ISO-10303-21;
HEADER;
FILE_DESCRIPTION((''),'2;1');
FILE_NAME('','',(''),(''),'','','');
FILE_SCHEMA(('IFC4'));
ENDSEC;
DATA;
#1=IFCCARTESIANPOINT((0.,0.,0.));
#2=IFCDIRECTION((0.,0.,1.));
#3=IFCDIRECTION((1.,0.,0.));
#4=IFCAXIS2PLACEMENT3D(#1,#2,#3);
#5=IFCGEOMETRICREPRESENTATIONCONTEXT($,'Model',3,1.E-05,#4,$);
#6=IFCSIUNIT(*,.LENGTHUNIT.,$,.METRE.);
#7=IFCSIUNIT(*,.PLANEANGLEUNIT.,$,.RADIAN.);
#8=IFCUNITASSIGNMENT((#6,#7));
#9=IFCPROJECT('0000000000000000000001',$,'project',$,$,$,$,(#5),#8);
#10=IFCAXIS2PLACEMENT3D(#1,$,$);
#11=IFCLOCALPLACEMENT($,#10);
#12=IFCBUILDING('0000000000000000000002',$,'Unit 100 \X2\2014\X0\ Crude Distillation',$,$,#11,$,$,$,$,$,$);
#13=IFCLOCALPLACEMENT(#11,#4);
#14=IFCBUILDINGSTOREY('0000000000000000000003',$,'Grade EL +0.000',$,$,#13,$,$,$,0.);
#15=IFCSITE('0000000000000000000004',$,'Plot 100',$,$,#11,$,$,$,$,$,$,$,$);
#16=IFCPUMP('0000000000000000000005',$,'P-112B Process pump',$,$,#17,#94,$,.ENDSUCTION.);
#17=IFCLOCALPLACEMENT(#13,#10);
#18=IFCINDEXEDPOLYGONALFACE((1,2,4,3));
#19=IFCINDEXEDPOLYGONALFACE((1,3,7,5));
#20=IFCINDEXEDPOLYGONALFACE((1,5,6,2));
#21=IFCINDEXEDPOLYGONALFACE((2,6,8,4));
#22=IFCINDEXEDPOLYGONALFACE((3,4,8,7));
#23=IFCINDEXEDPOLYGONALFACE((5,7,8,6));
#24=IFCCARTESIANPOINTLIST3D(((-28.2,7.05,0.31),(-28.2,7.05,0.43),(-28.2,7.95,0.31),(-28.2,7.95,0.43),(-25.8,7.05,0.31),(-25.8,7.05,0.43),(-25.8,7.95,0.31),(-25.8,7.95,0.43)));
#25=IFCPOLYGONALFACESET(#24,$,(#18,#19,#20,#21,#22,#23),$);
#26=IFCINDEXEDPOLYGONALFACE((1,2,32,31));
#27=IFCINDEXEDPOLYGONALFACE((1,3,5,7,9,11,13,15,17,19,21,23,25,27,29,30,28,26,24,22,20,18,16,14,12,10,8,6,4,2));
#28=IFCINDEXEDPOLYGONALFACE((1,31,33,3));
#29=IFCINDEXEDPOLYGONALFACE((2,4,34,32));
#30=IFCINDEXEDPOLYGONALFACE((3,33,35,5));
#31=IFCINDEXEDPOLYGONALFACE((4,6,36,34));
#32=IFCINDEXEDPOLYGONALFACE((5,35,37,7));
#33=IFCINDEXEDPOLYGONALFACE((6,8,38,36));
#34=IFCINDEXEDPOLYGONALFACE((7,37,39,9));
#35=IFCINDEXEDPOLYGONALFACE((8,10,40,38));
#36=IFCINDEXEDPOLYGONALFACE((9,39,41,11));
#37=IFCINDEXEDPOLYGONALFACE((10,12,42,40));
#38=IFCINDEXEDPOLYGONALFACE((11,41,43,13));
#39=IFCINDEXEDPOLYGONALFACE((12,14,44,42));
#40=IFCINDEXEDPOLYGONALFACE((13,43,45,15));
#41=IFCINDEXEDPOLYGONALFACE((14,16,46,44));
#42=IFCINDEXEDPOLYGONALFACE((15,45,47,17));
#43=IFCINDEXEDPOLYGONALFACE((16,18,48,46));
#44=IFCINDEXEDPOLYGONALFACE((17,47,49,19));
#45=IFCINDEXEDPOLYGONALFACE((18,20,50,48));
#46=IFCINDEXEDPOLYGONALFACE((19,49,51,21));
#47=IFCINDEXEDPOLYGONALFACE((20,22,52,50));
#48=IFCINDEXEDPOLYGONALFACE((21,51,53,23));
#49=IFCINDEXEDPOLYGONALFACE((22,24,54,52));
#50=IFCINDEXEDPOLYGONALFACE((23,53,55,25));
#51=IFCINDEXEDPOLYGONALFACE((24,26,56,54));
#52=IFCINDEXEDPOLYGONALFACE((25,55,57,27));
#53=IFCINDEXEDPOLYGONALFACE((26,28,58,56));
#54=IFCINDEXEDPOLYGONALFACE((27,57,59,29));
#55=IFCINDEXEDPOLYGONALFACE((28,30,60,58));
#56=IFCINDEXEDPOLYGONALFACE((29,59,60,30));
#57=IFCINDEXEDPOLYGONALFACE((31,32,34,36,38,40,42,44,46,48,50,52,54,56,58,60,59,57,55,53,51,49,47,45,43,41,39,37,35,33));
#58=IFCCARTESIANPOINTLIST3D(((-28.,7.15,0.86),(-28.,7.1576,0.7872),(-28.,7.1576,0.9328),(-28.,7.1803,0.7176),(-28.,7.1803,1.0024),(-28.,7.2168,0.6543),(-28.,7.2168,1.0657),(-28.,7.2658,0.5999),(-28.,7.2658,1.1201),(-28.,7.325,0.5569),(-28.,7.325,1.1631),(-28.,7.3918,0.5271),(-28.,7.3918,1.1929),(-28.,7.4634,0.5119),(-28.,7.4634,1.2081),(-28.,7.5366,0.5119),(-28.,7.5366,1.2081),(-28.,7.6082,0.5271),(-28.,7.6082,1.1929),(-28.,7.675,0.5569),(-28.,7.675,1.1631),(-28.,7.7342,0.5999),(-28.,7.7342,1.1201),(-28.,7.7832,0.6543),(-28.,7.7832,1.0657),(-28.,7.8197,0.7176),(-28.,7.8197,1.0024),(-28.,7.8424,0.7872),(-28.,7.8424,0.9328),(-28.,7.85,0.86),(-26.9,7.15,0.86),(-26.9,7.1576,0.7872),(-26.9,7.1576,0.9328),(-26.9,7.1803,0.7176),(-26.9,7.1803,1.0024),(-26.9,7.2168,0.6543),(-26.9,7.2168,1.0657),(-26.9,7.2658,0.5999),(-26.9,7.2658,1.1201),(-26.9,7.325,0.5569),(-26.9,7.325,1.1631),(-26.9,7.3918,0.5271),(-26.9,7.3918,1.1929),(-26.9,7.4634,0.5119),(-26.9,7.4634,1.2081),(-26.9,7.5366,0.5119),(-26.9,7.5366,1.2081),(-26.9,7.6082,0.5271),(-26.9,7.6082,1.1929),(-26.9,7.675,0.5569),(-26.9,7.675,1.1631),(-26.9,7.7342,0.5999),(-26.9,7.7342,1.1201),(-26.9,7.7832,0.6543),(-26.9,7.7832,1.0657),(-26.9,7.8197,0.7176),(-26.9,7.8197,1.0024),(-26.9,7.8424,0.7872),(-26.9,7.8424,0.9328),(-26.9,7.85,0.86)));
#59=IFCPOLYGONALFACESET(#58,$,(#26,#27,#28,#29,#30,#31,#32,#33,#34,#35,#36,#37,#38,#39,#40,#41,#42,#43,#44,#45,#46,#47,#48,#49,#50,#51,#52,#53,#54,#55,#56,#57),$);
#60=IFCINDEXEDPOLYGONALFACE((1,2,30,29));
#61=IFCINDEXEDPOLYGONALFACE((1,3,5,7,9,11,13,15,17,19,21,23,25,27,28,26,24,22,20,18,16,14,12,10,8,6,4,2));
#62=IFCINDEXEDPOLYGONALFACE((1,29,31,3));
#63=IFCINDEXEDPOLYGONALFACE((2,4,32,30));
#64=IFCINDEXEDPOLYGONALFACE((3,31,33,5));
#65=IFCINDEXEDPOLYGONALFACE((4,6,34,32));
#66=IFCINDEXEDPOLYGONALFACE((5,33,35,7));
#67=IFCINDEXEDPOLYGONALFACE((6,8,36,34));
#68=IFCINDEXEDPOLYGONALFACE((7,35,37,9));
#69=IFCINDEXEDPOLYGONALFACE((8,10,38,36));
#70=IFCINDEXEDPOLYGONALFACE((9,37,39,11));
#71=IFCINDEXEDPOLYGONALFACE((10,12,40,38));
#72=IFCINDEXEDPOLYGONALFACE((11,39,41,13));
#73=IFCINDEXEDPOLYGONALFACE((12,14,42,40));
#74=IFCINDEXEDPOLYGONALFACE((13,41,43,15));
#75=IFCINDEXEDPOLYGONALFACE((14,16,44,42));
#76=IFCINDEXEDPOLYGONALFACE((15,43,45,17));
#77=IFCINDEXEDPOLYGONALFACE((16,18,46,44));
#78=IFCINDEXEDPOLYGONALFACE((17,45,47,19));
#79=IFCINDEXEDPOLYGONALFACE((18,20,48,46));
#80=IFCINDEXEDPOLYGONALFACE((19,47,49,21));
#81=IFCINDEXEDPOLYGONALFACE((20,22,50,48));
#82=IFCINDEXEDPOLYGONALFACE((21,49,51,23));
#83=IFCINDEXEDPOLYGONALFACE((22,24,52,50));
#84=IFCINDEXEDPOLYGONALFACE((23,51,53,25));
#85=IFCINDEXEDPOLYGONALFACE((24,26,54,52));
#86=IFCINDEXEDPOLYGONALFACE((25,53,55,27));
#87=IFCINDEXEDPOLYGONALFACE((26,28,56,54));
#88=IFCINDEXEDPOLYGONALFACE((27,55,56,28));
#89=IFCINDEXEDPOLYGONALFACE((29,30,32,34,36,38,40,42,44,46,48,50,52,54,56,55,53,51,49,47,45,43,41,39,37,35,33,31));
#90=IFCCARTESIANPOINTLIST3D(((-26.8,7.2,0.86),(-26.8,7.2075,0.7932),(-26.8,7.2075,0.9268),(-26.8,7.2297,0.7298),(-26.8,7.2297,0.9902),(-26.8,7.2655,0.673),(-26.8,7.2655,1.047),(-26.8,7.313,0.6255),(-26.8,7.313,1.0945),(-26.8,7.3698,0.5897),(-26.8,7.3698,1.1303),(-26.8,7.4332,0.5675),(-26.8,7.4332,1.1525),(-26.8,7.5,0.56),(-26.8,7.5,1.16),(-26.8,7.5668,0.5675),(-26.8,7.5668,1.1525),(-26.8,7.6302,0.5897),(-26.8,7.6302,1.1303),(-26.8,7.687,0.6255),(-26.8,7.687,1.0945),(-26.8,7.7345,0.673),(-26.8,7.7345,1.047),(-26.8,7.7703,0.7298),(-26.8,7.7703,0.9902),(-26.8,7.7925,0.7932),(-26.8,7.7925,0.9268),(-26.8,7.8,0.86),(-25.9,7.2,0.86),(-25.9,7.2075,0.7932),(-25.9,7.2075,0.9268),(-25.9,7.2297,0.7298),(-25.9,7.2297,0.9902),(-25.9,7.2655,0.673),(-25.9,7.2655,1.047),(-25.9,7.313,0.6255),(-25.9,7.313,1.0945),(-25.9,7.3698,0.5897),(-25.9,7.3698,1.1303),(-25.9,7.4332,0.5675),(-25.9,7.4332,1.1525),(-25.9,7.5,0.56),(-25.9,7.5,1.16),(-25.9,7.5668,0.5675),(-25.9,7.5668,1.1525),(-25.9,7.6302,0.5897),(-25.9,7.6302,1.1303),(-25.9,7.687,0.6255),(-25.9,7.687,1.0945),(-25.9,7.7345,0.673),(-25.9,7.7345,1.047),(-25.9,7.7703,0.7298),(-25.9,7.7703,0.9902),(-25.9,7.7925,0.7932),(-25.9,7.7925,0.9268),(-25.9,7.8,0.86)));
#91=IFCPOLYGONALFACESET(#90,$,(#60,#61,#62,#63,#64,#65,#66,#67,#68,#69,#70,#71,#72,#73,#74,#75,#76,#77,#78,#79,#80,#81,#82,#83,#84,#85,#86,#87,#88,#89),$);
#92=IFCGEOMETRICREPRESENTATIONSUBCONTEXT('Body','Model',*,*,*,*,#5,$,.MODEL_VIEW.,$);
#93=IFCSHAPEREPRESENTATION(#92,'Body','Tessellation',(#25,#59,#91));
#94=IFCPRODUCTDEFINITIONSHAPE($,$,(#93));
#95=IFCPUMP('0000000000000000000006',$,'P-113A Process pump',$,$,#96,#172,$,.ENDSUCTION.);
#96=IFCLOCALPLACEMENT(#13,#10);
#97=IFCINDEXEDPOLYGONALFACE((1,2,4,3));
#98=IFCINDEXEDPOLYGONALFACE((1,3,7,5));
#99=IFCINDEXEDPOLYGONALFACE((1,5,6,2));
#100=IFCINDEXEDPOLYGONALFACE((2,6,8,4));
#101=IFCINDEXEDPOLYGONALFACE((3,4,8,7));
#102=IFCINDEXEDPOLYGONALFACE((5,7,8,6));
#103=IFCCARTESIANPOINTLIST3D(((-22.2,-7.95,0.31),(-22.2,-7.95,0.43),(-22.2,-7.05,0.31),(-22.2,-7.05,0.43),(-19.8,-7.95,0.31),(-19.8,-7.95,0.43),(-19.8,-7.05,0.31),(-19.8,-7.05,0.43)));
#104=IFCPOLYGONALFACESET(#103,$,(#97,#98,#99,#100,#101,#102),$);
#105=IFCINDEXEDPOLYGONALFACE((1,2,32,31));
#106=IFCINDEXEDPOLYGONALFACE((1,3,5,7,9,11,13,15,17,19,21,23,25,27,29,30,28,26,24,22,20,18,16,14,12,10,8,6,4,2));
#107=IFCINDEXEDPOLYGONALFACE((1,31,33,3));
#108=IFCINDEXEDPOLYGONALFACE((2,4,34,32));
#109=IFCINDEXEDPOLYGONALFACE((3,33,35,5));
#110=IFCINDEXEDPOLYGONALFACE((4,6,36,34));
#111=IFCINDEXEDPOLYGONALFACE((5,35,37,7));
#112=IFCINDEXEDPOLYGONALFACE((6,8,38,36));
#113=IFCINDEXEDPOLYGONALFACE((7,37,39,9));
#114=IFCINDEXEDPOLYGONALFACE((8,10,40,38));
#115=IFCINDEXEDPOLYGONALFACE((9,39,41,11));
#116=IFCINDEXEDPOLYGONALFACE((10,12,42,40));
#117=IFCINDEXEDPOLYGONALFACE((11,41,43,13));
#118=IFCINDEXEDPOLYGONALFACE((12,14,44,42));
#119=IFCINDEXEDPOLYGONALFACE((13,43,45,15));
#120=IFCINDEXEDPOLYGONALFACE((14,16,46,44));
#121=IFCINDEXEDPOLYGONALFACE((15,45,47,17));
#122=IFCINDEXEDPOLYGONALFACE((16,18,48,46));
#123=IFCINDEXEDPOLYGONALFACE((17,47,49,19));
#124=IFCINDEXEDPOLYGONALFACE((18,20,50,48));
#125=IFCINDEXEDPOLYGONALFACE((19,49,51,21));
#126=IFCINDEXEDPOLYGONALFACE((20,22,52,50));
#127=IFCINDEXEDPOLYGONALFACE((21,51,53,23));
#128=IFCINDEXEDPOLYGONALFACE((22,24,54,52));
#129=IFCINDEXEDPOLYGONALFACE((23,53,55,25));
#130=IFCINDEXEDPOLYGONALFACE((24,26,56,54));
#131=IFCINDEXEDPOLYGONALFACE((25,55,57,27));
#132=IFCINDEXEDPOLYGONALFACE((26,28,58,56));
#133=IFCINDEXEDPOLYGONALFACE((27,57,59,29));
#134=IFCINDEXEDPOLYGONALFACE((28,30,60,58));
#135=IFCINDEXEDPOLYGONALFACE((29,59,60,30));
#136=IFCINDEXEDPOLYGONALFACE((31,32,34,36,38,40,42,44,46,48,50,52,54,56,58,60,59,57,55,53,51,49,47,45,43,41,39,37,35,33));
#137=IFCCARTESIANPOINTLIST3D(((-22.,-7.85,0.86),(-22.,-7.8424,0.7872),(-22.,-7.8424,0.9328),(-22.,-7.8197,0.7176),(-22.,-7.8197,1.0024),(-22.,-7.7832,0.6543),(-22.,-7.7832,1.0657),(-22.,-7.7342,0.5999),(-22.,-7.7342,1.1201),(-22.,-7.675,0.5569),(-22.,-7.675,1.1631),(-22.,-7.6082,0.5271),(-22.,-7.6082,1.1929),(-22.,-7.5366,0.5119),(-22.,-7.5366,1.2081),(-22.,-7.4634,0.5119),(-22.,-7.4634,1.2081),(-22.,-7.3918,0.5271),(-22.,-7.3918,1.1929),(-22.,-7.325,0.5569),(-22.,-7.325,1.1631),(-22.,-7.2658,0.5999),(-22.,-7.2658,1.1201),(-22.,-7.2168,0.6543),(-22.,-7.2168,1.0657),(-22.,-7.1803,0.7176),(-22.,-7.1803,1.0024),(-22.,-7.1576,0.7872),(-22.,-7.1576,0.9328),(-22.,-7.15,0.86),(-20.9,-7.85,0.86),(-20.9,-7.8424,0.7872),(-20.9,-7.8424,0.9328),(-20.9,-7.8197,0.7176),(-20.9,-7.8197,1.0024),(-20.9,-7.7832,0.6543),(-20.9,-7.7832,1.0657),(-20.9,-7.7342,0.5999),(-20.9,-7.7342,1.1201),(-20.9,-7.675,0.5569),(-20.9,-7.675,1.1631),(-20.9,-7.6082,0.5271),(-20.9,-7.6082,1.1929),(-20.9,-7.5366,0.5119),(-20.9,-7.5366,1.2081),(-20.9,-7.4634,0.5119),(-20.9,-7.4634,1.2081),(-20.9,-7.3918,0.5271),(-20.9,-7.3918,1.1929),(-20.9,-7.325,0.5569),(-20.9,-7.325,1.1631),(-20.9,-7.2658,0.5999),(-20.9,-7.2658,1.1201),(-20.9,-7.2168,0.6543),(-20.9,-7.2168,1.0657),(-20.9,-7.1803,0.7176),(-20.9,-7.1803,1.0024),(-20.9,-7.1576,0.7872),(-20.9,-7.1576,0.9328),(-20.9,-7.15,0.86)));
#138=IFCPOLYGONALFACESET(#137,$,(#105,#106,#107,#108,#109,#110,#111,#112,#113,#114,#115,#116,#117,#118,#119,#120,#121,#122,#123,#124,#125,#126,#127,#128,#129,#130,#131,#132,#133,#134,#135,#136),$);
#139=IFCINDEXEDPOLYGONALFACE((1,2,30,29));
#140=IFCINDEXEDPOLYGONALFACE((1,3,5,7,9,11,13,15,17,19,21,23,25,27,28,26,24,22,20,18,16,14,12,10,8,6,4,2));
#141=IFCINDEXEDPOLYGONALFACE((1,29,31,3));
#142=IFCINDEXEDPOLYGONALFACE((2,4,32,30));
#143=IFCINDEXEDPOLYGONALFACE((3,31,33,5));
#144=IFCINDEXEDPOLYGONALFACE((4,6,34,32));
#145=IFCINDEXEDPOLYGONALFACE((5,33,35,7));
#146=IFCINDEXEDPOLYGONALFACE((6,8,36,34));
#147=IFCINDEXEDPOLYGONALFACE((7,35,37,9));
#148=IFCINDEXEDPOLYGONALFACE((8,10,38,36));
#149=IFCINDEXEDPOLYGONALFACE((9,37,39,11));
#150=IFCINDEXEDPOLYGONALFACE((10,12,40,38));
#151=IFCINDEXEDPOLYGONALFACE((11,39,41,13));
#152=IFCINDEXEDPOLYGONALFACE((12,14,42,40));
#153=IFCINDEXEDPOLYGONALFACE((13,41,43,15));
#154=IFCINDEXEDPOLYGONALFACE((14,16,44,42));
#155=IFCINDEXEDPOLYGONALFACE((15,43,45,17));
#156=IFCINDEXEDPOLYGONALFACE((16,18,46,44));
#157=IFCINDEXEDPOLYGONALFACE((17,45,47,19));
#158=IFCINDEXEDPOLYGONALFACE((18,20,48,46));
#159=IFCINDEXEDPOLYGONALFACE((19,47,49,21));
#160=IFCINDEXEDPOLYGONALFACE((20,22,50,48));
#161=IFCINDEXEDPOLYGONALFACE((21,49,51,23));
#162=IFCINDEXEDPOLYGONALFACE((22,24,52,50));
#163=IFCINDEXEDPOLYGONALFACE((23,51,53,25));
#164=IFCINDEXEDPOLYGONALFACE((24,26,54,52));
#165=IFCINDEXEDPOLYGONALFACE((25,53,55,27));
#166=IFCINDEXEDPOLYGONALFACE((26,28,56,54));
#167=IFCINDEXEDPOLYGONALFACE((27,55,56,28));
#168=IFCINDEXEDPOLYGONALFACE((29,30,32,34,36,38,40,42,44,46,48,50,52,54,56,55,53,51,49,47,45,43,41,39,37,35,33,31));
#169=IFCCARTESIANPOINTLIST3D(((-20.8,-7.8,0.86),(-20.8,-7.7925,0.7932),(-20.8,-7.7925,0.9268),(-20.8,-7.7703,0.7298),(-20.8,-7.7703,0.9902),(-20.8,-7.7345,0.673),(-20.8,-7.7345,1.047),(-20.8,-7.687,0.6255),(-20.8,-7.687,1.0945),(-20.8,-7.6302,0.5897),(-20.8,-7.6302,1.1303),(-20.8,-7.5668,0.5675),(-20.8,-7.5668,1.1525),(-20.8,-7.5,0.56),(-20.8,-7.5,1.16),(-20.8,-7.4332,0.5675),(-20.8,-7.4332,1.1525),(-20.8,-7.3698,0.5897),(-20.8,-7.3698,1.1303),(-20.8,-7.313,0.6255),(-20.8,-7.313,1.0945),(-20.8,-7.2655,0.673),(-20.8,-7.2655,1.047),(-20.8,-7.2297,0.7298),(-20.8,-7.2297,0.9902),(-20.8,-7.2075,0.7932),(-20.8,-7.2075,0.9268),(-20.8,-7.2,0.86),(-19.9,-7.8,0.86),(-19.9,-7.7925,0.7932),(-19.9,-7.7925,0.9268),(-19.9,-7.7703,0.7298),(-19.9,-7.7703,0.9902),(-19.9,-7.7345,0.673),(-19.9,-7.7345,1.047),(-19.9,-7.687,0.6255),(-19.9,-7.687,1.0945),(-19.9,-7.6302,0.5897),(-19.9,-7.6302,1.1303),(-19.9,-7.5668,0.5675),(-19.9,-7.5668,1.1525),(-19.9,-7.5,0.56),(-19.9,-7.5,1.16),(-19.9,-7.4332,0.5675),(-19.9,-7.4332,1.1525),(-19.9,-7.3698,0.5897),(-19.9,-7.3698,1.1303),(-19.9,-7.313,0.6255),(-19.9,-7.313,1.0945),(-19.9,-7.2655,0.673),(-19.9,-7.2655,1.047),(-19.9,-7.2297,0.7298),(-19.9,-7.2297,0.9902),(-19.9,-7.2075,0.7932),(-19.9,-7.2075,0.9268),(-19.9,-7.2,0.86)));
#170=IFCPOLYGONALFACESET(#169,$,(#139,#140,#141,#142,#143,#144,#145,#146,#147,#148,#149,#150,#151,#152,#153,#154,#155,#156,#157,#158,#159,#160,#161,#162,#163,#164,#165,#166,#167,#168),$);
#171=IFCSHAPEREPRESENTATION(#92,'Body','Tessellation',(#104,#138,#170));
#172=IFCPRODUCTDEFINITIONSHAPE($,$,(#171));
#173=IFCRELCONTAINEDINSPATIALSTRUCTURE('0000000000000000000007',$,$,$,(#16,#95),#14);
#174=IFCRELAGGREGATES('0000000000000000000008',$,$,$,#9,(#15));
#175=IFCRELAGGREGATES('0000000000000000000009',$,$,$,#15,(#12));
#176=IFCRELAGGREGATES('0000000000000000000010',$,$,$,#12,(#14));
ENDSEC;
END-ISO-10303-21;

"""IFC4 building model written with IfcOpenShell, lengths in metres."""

from ifc_helpers import new_model, si_unit, frame, origin, origin_with_axes, origin_2d, place, context, subcontext, project, spatial, rectangle, circle, extrude, element, save


model = new_model("IFC4")

# Units and contexts
model_context = context("Model", 3, precision=1e-05, world=origin_with_axes())
body_context = subcontext(model_context, "Body", "Model", "MODEL_VIEW")
ifc_project = project(units=[si_unit("LENGTHUNIT", "METRE"), si_unit("PLANEANGLEUNIT", "RADIAN")], contexts=[model_context])

# Site, building, storey
placement = place(None, origin())
site = spatial("IfcSite", under=ifc_project, at=placement, Name="Plot 100")
building = spatial("IfcBuilding", under=site, at=placement, Name="Unit 100 — Crude Distillation")
storey_placement = place(placement, origin_with_axes())
storey = spatial("IfcBuildingStorey", under=building, at=storey_placement, Name="Grade EL +0.000", Elevation=0.0)

# Pumps
pump_1_placement = place(storey_placement, origin_with_axes())
element("IfcPump", 1, at=pump_1_placement, inside=storey, Name="P-112B Process pump", PredefinedType="ENDSUCTION", context=body_context, shape_type="SweptSolid", body=[
    extrude(rectangle(XDim=2.4, YDim=0.9, at=origin_2d()), frame((-27.0, 7.5, 0.31), z_axis=(0.0, 0.0, 1.0), x_axis=(1.0, 0.0, 0.0)), (0.0, 0.0, 1.0), 0.12),
    extrude(circle(Radius=0.35, at=origin_2d()), frame((-28.0, 7.5, 0.86), z_axis=(1.0, 0.0, 0.0), x_axis=(0.0, 1.0, 0.0)), (0.0, 0.0, 1.0), 1.1),
    extrude(circle(Radius=0.3, at=origin_2d()), frame((-26.8, 7.5, 0.86), z_axis=(1.0, 0.0, 0.0), x_axis=(0.0, 1.0, 0.0)), (0.0, 0.0, 1.0), 0.9),
])
pump_2_placement = place(storey_placement, origin_with_axes())
element("IfcPump", 2, at=pump_2_placement, inside=storey, Name="P-113A Process pump", PredefinedType="ENDSUCTION", context=body_context, shape_type="SweptSolid", body=[
    extrude(rectangle(XDim=2.4, YDim=0.9, at=origin_2d()), frame((-21.0, -7.5, 0.31), z_axis=(0.0, 0.0, 1.0), x_axis=(1.0, 0.0, 0.0)), (0.0, 0.0, 1.0), 0.12),
    extrude(circle(Radius=0.35, at=origin_2d()), frame((-22.0, -7.5, 0.86), z_axis=(1.0, 0.0, 0.0), x_axis=(0.0, 1.0, 0.0)), (0.0, 0.0, 1.0), 1.1),
    extrude(circle(Radius=0.3, at=origin_2d()), frame((-20.8, -7.5, 0.86), z_axis=(1.0, 0.0, 0.0), x_axis=(0.0, 1.0, 0.0)), (0.0, 0.0, 1.0), 0.9),
])

save(model, "model.ifc")
